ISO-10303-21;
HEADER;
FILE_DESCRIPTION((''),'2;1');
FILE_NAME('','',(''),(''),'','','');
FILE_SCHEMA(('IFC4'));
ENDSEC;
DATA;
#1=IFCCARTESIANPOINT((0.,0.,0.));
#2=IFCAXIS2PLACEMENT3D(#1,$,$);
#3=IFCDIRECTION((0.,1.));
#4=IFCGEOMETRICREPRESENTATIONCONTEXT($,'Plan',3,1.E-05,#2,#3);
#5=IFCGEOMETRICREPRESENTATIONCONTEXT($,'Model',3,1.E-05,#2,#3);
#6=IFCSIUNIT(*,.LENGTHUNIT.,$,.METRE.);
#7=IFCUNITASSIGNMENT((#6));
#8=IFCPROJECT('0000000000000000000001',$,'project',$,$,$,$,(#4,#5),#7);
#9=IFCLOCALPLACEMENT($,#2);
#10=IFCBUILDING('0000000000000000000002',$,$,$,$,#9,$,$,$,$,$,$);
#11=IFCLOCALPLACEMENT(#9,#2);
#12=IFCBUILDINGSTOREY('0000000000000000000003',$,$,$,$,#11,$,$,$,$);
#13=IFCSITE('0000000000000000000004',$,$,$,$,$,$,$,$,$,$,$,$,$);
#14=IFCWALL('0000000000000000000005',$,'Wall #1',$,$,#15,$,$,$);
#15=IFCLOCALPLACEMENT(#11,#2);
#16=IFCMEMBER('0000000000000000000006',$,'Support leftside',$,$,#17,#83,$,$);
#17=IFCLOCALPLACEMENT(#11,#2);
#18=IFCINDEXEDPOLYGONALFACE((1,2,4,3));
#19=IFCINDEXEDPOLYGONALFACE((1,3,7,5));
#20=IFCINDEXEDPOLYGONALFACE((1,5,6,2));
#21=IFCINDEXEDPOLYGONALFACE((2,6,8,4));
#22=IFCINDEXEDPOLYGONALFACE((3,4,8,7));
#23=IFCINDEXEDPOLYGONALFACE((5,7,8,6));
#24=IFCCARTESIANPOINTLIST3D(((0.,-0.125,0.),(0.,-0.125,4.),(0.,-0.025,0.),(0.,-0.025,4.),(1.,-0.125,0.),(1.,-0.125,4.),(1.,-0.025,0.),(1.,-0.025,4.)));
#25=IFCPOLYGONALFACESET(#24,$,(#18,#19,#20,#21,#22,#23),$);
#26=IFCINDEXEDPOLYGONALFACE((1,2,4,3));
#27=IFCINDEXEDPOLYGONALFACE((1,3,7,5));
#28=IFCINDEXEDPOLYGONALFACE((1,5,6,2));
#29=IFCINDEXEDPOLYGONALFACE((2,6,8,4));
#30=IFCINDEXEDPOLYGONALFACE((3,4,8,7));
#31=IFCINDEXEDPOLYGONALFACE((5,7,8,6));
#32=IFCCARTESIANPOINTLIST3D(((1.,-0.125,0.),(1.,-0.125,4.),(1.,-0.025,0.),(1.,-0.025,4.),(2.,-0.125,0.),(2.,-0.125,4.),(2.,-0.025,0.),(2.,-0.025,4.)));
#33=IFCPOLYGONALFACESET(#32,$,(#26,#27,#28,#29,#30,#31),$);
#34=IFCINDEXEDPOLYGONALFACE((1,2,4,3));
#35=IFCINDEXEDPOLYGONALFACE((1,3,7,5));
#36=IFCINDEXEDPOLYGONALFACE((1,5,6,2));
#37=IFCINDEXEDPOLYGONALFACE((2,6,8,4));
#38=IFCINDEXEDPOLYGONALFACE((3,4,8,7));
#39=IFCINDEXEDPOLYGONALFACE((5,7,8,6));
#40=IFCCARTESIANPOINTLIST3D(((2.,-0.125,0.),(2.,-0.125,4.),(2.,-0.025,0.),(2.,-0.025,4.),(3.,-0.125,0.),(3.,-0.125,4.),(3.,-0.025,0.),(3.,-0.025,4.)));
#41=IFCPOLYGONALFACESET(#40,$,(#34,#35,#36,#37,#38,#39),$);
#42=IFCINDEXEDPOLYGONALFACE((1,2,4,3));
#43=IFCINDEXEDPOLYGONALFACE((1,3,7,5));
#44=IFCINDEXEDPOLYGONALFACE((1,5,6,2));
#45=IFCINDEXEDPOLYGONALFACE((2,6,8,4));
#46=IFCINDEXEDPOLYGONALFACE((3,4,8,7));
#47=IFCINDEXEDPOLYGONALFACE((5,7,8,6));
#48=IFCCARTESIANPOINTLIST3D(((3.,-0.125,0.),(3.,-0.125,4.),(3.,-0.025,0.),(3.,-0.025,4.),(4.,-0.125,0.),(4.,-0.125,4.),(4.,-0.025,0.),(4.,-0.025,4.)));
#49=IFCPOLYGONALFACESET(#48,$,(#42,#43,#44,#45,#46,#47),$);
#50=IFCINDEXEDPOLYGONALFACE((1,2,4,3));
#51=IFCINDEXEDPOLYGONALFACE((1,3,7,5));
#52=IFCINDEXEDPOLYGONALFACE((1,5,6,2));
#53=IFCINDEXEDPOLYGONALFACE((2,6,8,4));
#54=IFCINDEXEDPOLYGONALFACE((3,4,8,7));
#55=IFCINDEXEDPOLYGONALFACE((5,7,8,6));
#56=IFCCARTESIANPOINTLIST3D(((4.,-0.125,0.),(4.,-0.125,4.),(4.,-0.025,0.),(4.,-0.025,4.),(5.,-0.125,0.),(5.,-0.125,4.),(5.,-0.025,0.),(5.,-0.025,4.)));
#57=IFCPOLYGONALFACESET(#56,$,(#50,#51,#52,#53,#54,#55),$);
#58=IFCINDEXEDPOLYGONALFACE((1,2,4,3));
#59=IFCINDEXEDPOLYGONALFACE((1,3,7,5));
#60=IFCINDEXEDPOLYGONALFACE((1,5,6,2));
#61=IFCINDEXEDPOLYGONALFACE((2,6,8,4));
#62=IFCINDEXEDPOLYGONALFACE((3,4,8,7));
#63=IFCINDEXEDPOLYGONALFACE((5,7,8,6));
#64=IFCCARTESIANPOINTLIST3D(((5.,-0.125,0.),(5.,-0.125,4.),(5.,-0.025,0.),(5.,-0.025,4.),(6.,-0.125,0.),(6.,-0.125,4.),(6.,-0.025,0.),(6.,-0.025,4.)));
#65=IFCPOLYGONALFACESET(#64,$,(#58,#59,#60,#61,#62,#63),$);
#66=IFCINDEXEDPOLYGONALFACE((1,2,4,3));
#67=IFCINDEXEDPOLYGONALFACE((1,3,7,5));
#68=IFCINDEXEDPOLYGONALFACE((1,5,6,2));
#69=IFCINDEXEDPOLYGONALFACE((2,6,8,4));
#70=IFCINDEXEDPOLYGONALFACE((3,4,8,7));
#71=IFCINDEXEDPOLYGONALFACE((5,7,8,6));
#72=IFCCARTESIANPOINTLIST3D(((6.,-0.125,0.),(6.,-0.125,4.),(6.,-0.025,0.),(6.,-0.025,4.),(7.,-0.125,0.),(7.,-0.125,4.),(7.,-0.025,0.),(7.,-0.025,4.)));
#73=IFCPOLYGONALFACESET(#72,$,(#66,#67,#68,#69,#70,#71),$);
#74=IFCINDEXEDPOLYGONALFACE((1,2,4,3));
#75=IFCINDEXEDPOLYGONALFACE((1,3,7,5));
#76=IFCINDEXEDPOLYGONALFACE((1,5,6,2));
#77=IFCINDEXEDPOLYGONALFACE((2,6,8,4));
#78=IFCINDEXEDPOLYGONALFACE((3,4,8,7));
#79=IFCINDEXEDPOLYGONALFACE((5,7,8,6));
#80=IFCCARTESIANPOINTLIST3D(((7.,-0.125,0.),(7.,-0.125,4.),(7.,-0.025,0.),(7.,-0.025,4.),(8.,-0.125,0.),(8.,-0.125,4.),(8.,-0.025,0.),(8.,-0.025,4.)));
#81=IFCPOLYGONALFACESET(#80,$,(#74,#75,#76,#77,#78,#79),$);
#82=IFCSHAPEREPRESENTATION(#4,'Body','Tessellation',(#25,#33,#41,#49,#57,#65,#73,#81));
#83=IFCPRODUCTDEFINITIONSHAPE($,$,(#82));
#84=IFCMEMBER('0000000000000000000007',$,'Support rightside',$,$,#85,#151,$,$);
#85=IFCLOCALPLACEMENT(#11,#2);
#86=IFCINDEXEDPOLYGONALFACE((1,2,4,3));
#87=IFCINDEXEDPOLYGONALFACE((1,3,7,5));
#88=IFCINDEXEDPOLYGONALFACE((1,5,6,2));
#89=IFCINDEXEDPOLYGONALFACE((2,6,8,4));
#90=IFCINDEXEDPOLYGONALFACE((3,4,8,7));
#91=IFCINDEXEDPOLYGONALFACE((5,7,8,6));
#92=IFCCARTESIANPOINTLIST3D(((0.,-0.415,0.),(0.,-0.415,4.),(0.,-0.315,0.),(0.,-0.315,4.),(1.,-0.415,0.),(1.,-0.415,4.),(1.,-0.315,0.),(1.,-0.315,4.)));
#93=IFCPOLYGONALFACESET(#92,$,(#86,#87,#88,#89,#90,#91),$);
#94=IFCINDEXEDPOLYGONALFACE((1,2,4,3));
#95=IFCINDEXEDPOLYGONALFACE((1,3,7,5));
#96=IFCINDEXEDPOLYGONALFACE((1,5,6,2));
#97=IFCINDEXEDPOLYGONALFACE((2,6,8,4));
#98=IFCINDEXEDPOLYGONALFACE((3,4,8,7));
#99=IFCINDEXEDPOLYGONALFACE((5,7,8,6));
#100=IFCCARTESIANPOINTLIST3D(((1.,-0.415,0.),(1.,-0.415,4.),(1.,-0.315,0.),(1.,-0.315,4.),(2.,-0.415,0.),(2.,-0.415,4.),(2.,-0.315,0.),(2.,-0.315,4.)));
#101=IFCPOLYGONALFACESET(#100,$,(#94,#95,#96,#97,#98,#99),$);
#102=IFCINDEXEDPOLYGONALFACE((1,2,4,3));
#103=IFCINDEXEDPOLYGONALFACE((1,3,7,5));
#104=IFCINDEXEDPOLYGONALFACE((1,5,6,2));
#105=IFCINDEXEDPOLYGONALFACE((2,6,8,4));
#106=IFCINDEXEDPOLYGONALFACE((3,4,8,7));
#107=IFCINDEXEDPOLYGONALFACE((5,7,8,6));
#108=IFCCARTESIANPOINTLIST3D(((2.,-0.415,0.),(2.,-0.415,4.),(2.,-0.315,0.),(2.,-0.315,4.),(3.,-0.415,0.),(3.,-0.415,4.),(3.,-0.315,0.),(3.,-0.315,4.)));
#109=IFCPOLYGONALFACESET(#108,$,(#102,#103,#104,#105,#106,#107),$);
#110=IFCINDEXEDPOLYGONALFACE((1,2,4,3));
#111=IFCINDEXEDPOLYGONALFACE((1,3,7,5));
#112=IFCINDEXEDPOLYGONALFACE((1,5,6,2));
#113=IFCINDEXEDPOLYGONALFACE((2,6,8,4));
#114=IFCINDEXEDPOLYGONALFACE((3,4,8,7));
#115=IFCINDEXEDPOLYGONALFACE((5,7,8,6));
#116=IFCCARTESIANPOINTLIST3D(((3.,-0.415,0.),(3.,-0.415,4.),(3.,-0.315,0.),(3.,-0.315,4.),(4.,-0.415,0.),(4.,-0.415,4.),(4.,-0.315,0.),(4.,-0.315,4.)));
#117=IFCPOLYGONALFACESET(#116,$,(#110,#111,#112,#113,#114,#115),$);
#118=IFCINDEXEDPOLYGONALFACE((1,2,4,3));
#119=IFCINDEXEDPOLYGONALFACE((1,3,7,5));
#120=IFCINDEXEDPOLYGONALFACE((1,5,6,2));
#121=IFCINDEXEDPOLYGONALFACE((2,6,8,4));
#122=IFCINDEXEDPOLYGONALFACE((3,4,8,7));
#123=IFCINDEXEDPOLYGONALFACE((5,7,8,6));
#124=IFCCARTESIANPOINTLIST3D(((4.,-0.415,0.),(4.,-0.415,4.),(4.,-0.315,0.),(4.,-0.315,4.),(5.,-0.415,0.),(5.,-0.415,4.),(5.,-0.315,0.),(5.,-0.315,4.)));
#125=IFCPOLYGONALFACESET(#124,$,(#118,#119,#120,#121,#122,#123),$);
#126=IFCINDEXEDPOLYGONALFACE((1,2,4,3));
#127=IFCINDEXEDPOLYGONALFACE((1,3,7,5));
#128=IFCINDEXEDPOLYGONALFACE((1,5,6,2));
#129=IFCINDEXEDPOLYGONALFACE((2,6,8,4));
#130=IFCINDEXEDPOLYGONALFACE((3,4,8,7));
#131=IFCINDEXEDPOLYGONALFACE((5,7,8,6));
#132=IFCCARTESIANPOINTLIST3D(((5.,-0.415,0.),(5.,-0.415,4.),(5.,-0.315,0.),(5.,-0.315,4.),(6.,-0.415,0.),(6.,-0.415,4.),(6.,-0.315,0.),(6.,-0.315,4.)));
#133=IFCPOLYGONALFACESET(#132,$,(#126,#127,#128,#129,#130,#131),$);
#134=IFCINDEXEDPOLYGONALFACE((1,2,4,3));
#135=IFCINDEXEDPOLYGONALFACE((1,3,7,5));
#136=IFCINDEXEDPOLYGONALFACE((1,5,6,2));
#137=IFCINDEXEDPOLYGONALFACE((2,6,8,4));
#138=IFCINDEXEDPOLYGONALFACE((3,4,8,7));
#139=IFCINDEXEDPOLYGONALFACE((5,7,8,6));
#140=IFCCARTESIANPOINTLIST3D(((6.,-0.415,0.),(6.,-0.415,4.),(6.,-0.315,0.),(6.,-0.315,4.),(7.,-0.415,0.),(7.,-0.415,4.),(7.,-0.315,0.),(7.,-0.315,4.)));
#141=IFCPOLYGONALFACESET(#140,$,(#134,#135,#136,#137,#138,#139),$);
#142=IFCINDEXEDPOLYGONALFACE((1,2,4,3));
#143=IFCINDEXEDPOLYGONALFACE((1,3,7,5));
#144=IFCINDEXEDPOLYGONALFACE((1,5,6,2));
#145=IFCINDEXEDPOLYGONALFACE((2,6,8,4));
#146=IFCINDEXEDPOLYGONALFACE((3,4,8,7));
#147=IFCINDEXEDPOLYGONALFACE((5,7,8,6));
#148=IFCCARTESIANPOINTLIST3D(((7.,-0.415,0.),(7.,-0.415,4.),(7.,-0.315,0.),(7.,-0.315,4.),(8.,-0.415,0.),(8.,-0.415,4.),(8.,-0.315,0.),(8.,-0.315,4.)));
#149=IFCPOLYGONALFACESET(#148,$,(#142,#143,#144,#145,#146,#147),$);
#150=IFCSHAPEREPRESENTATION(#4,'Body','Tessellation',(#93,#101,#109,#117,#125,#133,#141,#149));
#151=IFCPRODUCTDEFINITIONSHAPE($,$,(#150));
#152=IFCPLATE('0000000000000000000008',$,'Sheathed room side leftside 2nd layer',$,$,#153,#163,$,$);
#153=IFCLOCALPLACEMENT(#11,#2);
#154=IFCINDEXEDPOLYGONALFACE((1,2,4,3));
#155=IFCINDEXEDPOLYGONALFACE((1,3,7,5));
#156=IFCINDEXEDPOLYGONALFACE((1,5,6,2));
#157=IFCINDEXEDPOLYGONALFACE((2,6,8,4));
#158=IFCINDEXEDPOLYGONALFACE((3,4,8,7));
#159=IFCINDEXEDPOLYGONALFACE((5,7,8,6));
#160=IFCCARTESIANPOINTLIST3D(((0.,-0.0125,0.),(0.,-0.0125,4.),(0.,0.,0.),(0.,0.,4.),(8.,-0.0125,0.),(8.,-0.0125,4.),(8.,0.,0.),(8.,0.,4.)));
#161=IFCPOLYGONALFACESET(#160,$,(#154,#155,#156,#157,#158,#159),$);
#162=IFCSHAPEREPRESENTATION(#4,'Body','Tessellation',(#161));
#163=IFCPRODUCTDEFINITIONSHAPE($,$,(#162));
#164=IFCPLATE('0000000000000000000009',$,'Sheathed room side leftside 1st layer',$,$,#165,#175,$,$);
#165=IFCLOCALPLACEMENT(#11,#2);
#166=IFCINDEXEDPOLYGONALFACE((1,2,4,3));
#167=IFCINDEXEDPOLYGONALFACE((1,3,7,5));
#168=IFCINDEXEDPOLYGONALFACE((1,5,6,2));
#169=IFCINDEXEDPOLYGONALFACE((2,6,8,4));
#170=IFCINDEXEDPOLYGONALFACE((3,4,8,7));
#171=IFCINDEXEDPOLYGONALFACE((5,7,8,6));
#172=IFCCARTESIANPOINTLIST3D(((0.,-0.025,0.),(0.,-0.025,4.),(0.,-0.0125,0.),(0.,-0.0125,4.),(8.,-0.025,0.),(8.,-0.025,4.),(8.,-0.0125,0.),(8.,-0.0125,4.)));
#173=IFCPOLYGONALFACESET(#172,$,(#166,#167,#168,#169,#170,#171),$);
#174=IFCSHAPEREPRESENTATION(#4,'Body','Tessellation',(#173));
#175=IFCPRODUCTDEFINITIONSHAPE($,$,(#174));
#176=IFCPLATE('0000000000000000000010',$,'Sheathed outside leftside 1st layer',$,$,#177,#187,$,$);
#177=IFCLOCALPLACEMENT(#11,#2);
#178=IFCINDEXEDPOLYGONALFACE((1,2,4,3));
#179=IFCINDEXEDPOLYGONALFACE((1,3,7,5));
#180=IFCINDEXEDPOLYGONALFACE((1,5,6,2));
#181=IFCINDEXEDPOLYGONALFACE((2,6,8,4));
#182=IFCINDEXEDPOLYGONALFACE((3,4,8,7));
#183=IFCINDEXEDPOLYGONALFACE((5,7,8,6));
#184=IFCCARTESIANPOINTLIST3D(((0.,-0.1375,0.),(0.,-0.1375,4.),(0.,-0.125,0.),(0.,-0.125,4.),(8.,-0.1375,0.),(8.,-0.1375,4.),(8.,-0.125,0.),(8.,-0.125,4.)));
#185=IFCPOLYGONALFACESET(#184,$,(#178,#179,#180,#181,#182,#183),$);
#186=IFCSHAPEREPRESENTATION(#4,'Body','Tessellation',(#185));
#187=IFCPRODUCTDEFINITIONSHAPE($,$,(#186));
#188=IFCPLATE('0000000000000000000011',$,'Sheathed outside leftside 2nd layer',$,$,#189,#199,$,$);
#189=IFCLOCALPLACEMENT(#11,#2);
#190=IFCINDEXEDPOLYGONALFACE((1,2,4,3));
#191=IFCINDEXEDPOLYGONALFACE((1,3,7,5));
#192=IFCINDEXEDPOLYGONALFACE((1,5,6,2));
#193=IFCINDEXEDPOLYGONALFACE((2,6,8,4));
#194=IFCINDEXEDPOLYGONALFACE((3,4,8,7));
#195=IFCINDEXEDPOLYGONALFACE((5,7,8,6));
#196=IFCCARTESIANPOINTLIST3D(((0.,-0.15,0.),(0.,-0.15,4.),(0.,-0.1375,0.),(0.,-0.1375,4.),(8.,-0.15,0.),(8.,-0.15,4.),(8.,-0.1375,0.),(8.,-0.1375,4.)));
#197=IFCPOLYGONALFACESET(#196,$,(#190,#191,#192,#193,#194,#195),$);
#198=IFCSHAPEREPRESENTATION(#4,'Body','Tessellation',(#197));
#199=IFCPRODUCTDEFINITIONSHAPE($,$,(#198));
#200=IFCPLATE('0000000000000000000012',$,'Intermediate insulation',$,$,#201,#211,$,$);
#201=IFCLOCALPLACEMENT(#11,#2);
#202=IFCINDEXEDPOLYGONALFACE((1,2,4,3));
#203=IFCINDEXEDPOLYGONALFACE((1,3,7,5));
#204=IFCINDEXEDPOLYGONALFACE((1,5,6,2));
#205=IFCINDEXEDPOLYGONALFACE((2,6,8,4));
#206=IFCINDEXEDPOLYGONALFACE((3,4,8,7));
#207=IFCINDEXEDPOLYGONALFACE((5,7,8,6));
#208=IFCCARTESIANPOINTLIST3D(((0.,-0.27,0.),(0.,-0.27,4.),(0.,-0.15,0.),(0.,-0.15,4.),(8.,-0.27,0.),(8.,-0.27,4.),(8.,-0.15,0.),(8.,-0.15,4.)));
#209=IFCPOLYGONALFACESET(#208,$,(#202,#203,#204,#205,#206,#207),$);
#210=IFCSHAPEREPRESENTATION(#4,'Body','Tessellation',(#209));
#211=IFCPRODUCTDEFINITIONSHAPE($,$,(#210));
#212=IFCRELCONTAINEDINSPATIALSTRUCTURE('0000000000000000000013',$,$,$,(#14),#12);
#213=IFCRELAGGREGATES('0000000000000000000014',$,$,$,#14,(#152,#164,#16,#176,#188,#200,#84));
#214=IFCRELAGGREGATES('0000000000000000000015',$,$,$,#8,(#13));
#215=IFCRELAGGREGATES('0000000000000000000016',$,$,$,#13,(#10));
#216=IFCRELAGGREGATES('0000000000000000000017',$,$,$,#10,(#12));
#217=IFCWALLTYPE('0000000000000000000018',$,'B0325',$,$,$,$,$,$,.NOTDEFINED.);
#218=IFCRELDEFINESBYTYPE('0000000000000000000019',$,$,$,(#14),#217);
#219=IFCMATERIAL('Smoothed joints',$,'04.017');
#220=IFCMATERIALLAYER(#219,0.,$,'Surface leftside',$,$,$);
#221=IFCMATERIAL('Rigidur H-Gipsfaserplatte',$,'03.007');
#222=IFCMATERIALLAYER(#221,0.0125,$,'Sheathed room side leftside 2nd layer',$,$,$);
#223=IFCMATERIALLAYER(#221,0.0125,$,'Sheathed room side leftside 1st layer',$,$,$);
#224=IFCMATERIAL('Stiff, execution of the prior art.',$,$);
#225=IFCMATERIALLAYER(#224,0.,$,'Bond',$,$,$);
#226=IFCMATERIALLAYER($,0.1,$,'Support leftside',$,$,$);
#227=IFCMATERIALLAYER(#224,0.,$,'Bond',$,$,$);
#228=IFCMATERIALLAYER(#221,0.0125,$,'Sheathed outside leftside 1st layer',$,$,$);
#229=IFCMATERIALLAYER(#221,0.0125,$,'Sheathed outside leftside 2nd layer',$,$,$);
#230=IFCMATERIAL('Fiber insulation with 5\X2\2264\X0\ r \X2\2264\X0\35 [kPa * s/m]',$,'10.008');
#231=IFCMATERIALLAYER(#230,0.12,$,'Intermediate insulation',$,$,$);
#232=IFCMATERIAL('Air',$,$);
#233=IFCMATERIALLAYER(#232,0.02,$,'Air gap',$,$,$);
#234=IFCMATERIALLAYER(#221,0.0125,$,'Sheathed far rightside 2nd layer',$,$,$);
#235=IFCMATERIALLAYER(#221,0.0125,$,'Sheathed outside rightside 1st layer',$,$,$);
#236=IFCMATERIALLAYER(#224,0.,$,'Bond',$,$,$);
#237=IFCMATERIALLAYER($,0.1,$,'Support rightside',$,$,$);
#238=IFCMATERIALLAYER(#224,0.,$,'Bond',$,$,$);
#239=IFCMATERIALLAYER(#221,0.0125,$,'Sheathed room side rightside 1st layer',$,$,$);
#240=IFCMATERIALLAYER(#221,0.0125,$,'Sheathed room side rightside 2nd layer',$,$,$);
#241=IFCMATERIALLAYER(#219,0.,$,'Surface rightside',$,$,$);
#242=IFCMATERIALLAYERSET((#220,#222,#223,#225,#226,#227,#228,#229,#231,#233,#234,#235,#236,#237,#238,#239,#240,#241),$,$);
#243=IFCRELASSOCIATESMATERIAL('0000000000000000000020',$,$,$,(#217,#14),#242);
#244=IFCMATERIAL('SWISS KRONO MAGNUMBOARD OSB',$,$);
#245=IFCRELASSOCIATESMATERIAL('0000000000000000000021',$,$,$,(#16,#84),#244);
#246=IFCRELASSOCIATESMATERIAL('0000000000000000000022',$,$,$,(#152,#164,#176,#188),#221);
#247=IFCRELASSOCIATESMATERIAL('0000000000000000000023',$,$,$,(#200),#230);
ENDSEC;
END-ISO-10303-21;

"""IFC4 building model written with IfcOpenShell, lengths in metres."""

from ifc_helpers import new_model, si_unit, direction, frame, frame_2d, origin, origin_with_axes, place, context, project, spatial, rectangle, extrude, material, layer, layer_set, type_object, element, aggregate, save


model = new_model("IFC4")

# Units and contexts
plan_context = context("Plan", 3, precision=1e-05, world=origin(), true_north=direction((0.0, 1.0)))
model_context = context("Model", 3, precision=1e-05, world=origin(), true_north=direction((0.0, 1.0)))
ifc_project = project(units=[si_unit("LENGTHUNIT", "METRE")], contexts=[plan_context, model_context])

# Site, building, storey
site = spatial("IfcSite", under=ifc_project)
building_placement = place(None, origin())
building = spatial("IfcBuilding", under=site, at=building_placement)
storey_placement = place(building_placement, origin())
storey = spatial("IfcBuildingStorey", under=building, at=storey_placement)

# Wall, members, plates
ifc_material_1 = material(Name="Smoothed joints", Category="04.017")
ifc_layer_1 = layer(ifc_material_1, 0.0, Name="Surface leftside")
ifc_material_2 = material(Name="Rigidur H-Gipsfaserplatte", Category="03.007")
ifc_layer_2 = layer(ifc_material_2, 0.0125, Name="Sheathed room side leftside 2nd layer")
ifc_layer_3 = layer(ifc_material_2, 0.0125, Name="Sheathed room side leftside 1st layer")
ifc_material_3 = material(Name="Stiff, execution of the prior art.")
ifc_layer_4 = layer(ifc_material_3, 0.0, Name="Bond")
ifc_layer_5 = layer(None, 0.1, Name="Support leftside")
ifc_layer_6 = layer(ifc_material_3, 0.0, Name="Bond")
ifc_layer_7 = layer(ifc_material_2, 0.0125, Name="Sheathed outside leftside 1st layer")
ifc_layer_8 = layer(ifc_material_2, 0.0125, Name="Sheathed outside leftside 2nd layer")
ifc_material_4 = material(Name="Fiber insulation with 5≤ r ≤35 [kPa * s/m]", Category="10.008")
ifc_layer_9 = layer(ifc_material_4, 0.12, Name="Intermediate insulation")
ifc_material_5 = material(Name="Air")
ifc_layer_10 = layer(ifc_material_5, 0.02, Name="Air gap")
ifc_layer_11 = layer(ifc_material_2, 0.0125, Name="Sheathed far rightside 2nd layer")
ifc_layer_12 = layer(ifc_material_2, 0.0125, Name="Sheathed outside rightside 1st layer")
ifc_layer_13 = layer(ifc_material_3, 0.0, Name="Bond")
ifc_layer_14 = layer(None, 0.1, Name="Support rightside")
ifc_layer_15 = layer(ifc_material_3, 0.0, Name="Bond")
ifc_layer_16 = layer(ifc_material_2, 0.0125, Name="Sheathed room side rightside 1st layer")
ifc_layer_17 = layer(ifc_material_2, 0.0125, Name="Sheathed room side rightside 2nd layer")
ifc_layer_18 = layer(ifc_material_1, 0.0, Name="Surface rightside")
ifc_layer_set = layer_set([ifc_layer_1, ifc_layer_2, ifc_layer_3, ifc_layer_4, ifc_layer_5, ifc_layer_6, ifc_layer_7, ifc_layer_8, ifc_layer_9, ifc_layer_10, ifc_layer_11, ifc_layer_12, ifc_layer_13, ifc_layer_14, ifc_layer_15, ifc_layer_16, ifc_layer_17, ifc_layer_18])
wall_type = type_object("IfcWallType", Name="B0325", PredefinedType="NOTDEFINED", material=ifc_layer_set)
wall_placement = place(None, frame((0.0, 0.0, 0.0), z_axis=(0.0, -1.0, 0.0), x_axis=(1.0, 0.0, 0.0)))
wall = element("IfcWall", 1, at=wall_placement, inside=storey, type_object=wall_type, material=ifc_layer_set, Name="Wall #1")
ifc_material_6 = material(Name="SWISS KRONO MAGNUMBOARD OSB")
member_1_placement = place(wall_placement, origin())
member_1 = element("IfcMember", 2, at=member_1_placement, material=ifc_material_6, Name="Support leftside", context=plan_context, shape_type="SweptSolid", body=[
    extrude(rectangle(XDim=1.0, YDim=0.1, at=frame_2d((0.5, 0.05), x_axis=(1.0, 0.0))), frame((0.0, 4.0, 0.025), z_axis=(0.0, -1.0, 0.0), x_axis=(1.0, 0.0, 0.0)), (0.0, 0.0, 1.0), 4.0),
    extrude(rectangle(XDim=1.0, YDim=0.1, at=frame_2d((0.5, 0.05), x_axis=(1.0, 0.0))), frame((1.0, 4.0, 0.025), z_axis=(0.0, -1.0, 0.0), x_axis=(1.0, 0.0, 0.0)), (0.0, 0.0, 1.0), 4.0),
    extrude(rectangle(XDim=1.0, YDim=0.1, at=frame_2d((0.5, 0.05), x_axis=(1.0, 0.0))), frame((2.0, 4.0, 0.025), z_axis=(0.0, -1.0, 0.0), x_axis=(1.0, 0.0, 0.0)), (0.0, 0.0, 1.0), 4.0),
    extrude(rectangle(XDim=1.0, YDim=0.1, at=frame_2d((0.5, 0.05), x_axis=(1.0, 0.0))), frame((3.0, 4.0, 0.025), z_axis=(0.0, -1.0, 0.0), x_axis=(1.0, 0.0, 0.0)), (0.0, 0.0, 1.0), 4.0),
    extrude(rectangle(XDim=1.0, YDim=0.1, at=frame_2d((0.5, 0.05), x_axis=(1.0, 0.0))), frame((4.0, 4.0, 0.025), z_axis=(0.0, -1.0, 0.0), x_axis=(1.0, 0.0, 0.0)), (0.0, 0.0, 1.0), 4.0),
    extrude(rectangle(XDim=1.0, YDim=0.1, at=frame_2d((0.5, 0.05), x_axis=(1.0, 0.0))), frame((5.0, 4.0, 0.025), z_axis=(0.0, -1.0, 0.0), x_axis=(1.0, 0.0, 0.0)), (0.0, 0.0, 1.0), 4.0),
    extrude(rectangle(XDim=1.0, YDim=0.1, at=frame_2d((0.5, 0.05), x_axis=(1.0, 0.0))), frame((6.0, 4.0, 0.025), z_axis=(0.0, -1.0, 0.0), x_axis=(1.0, 0.0, 0.0)), (0.0, 0.0, 1.0), 4.0),
    extrude(rectangle(XDim=1.0, YDim=0.1, at=frame_2d((0.5, 0.05), x_axis=(1.0, 0.0))), frame((7.0, 4.0, 0.025), z_axis=(0.0, -1.0, 0.0), x_axis=(1.0, 0.0, 0.0)), (0.0, 0.0, 1.0), 4.0),
])
member_2_placement = place(wall_placement, origin())
member_2 = element("IfcMember", 3, at=member_2_placement, material=ifc_material_6, Name="Support rightside", context=plan_context, shape_type="SweptSolid", body=[
    extrude(rectangle(XDim=1.0, YDim=0.1, at=frame_2d((0.5, 0.05), x_axis=(1.0, 0.0))), frame((0.0, 4.0, 0.315), z_axis=(0.0, -1.0, 0.0), x_axis=(1.0, 0.0, 0.0)), (0.0, 0.0, 1.0), 4.0),
    extrude(rectangle(XDim=1.0, YDim=0.1, at=frame_2d((0.5, 0.05), x_axis=(1.0, 0.0))), frame((1.0, 4.0, 0.315), z_axis=(0.0, -1.0, 0.0), x_axis=(1.0, 0.0, 0.0)), (0.0, 0.0, 1.0), 4.0),
    extrude(rectangle(XDim=1.0, YDim=0.1, at=frame_2d((0.5, 0.05), x_axis=(1.0, 0.0))), frame((2.0, 4.0, 0.315), z_axis=(0.0, -1.0, 0.0), x_axis=(1.0, 0.0, 0.0)), (0.0, 0.0, 1.0), 4.0),
    extrude(rectangle(XDim=1.0, YDim=0.1, at=frame_2d((0.5, 0.05), x_axis=(1.0, 0.0))), frame((3.0, 4.0, 0.315), z_axis=(0.0, -1.0, 0.0), x_axis=(1.0, 0.0, 0.0)), (0.0, 0.0, 1.0), 4.0),
    extrude(rectangle(XDim=1.0, YDim=0.1, at=frame_2d((0.5, 0.05), x_axis=(1.0, 0.0))), frame((4.0, 4.0, 0.315), z_axis=(0.0, -1.0, 0.0), x_axis=(1.0, 0.0, 0.0)), (0.0, 0.0, 1.0), 4.0),
    extrude(rectangle(XDim=1.0, YDim=0.1, at=frame_2d((0.5, 0.05), x_axis=(1.0, 0.0))), frame((5.0, 4.0, 0.315), z_axis=(0.0, -1.0, 0.0), x_axis=(1.0, 0.0, 0.0)), (0.0, 0.0, 1.0), 4.0),
    extrude(rectangle(XDim=1.0, YDim=0.1, at=frame_2d((0.5, 0.05), x_axis=(1.0, 0.0))), frame((6.0, 4.0, 0.315), z_axis=(0.0, -1.0, 0.0), x_axis=(1.0, 0.0, 0.0)), (0.0, 0.0, 1.0), 4.0),
    extrude(rectangle(XDim=1.0, YDim=0.1, at=frame_2d((0.5, 0.05), x_axis=(1.0, 0.0))), frame((7.0, 4.0, 0.315), z_axis=(0.0, -1.0, 0.0), x_axis=(1.0, 0.0, 0.0)), (0.0, 0.0, 1.0), 4.0),
])
plate_1_placement = place(wall_placement, origin())
plate_1 = element("IfcPlate", 4, at=plate_1_placement, material=ifc_material_2, Name="Sheathed room side leftside 2nd layer", context=plan_context, shape_type="SweptSolid", body=[
    extrude(rectangle(XDim=8.0, YDim=4.0, at=frame_2d((4.0, 2.0), x_axis=(1.0, 0.0))), origin_with_axes(), (0.0, 0.0, 1.0), 0.0125),
])
plate_2_placement = place(wall_placement, origin())
plate_2 = element("IfcPlate", 5, at=plate_2_placement, material=ifc_material_2, Name="Sheathed room side leftside 1st layer", context=plan_context, shape_type="SweptSolid", body=[
    extrude(rectangle(XDim=8.0, YDim=4.0, at=frame_2d((4.0, 2.0), x_axis=(1.0, 0.0))), frame((0.0, 0.0, 0.0125), z_axis=(0.0, 0.0, 1.0), x_axis=(1.0, 0.0, 0.0)), (0.0, 0.0, 1.0), 0.0125),
])
plate_3_placement = place(wall_placement, origin())
plate_3 = element("IfcPlate", 6, at=plate_3_placement, material=ifc_material_2, Name="Sheathed outside leftside 1st layer", context=plan_context, shape_type="SweptSolid", body=[
    extrude(rectangle(XDim=8.0, YDim=4.0, at=frame_2d((4.0, 2.0), x_axis=(1.0, 0.0))), frame((0.0, 0.0, 0.125), z_axis=(0.0, 0.0, 1.0), x_axis=(1.0, 0.0, 0.0)), (0.0, 0.0, 1.0), 0.0125),
])
plate_4_placement = place(wall_placement, origin())
plate_4 = element("IfcPlate", 7, at=plate_4_placement, material=ifc_material_2, Name="Sheathed outside leftside 2nd layer", context=plan_context, shape_type="SweptSolid", body=[
    extrude(rectangle(XDim=8.0, YDim=4.0, at=frame_2d((4.0, 2.0), x_axis=(1.0, 0.0))), frame((0.0, 0.0, 0.1375), z_axis=(0.0, 0.0, 1.0), x_axis=(1.0, 0.0, 0.0)), (0.0, 0.0, 1.0), 0.0125),
])
plate_5_placement = place(wall_placement, origin())
plate_5 = element("IfcPlate", 8, at=plate_5_placement, material=ifc_material_4, Name="Intermediate insulation", context=plan_context, shape_type="SweptSolid", body=[
    extrude(rectangle(XDim=8.0, YDim=4.0, at=frame_2d((4.0, 2.0), x_axis=(1.0, 0.0))), frame((0.0, 0.0, 0.15), z_axis=(0.0, 0.0, 1.0), x_axis=(1.0, 0.0, 0.0)), (0.0, 0.0, 1.0), 0.12),
])
aggregate(wall, [plate_1, plate_2, member_1, plate_3, plate_4, plate_5, member_2])

save(model, "model.ifc")
